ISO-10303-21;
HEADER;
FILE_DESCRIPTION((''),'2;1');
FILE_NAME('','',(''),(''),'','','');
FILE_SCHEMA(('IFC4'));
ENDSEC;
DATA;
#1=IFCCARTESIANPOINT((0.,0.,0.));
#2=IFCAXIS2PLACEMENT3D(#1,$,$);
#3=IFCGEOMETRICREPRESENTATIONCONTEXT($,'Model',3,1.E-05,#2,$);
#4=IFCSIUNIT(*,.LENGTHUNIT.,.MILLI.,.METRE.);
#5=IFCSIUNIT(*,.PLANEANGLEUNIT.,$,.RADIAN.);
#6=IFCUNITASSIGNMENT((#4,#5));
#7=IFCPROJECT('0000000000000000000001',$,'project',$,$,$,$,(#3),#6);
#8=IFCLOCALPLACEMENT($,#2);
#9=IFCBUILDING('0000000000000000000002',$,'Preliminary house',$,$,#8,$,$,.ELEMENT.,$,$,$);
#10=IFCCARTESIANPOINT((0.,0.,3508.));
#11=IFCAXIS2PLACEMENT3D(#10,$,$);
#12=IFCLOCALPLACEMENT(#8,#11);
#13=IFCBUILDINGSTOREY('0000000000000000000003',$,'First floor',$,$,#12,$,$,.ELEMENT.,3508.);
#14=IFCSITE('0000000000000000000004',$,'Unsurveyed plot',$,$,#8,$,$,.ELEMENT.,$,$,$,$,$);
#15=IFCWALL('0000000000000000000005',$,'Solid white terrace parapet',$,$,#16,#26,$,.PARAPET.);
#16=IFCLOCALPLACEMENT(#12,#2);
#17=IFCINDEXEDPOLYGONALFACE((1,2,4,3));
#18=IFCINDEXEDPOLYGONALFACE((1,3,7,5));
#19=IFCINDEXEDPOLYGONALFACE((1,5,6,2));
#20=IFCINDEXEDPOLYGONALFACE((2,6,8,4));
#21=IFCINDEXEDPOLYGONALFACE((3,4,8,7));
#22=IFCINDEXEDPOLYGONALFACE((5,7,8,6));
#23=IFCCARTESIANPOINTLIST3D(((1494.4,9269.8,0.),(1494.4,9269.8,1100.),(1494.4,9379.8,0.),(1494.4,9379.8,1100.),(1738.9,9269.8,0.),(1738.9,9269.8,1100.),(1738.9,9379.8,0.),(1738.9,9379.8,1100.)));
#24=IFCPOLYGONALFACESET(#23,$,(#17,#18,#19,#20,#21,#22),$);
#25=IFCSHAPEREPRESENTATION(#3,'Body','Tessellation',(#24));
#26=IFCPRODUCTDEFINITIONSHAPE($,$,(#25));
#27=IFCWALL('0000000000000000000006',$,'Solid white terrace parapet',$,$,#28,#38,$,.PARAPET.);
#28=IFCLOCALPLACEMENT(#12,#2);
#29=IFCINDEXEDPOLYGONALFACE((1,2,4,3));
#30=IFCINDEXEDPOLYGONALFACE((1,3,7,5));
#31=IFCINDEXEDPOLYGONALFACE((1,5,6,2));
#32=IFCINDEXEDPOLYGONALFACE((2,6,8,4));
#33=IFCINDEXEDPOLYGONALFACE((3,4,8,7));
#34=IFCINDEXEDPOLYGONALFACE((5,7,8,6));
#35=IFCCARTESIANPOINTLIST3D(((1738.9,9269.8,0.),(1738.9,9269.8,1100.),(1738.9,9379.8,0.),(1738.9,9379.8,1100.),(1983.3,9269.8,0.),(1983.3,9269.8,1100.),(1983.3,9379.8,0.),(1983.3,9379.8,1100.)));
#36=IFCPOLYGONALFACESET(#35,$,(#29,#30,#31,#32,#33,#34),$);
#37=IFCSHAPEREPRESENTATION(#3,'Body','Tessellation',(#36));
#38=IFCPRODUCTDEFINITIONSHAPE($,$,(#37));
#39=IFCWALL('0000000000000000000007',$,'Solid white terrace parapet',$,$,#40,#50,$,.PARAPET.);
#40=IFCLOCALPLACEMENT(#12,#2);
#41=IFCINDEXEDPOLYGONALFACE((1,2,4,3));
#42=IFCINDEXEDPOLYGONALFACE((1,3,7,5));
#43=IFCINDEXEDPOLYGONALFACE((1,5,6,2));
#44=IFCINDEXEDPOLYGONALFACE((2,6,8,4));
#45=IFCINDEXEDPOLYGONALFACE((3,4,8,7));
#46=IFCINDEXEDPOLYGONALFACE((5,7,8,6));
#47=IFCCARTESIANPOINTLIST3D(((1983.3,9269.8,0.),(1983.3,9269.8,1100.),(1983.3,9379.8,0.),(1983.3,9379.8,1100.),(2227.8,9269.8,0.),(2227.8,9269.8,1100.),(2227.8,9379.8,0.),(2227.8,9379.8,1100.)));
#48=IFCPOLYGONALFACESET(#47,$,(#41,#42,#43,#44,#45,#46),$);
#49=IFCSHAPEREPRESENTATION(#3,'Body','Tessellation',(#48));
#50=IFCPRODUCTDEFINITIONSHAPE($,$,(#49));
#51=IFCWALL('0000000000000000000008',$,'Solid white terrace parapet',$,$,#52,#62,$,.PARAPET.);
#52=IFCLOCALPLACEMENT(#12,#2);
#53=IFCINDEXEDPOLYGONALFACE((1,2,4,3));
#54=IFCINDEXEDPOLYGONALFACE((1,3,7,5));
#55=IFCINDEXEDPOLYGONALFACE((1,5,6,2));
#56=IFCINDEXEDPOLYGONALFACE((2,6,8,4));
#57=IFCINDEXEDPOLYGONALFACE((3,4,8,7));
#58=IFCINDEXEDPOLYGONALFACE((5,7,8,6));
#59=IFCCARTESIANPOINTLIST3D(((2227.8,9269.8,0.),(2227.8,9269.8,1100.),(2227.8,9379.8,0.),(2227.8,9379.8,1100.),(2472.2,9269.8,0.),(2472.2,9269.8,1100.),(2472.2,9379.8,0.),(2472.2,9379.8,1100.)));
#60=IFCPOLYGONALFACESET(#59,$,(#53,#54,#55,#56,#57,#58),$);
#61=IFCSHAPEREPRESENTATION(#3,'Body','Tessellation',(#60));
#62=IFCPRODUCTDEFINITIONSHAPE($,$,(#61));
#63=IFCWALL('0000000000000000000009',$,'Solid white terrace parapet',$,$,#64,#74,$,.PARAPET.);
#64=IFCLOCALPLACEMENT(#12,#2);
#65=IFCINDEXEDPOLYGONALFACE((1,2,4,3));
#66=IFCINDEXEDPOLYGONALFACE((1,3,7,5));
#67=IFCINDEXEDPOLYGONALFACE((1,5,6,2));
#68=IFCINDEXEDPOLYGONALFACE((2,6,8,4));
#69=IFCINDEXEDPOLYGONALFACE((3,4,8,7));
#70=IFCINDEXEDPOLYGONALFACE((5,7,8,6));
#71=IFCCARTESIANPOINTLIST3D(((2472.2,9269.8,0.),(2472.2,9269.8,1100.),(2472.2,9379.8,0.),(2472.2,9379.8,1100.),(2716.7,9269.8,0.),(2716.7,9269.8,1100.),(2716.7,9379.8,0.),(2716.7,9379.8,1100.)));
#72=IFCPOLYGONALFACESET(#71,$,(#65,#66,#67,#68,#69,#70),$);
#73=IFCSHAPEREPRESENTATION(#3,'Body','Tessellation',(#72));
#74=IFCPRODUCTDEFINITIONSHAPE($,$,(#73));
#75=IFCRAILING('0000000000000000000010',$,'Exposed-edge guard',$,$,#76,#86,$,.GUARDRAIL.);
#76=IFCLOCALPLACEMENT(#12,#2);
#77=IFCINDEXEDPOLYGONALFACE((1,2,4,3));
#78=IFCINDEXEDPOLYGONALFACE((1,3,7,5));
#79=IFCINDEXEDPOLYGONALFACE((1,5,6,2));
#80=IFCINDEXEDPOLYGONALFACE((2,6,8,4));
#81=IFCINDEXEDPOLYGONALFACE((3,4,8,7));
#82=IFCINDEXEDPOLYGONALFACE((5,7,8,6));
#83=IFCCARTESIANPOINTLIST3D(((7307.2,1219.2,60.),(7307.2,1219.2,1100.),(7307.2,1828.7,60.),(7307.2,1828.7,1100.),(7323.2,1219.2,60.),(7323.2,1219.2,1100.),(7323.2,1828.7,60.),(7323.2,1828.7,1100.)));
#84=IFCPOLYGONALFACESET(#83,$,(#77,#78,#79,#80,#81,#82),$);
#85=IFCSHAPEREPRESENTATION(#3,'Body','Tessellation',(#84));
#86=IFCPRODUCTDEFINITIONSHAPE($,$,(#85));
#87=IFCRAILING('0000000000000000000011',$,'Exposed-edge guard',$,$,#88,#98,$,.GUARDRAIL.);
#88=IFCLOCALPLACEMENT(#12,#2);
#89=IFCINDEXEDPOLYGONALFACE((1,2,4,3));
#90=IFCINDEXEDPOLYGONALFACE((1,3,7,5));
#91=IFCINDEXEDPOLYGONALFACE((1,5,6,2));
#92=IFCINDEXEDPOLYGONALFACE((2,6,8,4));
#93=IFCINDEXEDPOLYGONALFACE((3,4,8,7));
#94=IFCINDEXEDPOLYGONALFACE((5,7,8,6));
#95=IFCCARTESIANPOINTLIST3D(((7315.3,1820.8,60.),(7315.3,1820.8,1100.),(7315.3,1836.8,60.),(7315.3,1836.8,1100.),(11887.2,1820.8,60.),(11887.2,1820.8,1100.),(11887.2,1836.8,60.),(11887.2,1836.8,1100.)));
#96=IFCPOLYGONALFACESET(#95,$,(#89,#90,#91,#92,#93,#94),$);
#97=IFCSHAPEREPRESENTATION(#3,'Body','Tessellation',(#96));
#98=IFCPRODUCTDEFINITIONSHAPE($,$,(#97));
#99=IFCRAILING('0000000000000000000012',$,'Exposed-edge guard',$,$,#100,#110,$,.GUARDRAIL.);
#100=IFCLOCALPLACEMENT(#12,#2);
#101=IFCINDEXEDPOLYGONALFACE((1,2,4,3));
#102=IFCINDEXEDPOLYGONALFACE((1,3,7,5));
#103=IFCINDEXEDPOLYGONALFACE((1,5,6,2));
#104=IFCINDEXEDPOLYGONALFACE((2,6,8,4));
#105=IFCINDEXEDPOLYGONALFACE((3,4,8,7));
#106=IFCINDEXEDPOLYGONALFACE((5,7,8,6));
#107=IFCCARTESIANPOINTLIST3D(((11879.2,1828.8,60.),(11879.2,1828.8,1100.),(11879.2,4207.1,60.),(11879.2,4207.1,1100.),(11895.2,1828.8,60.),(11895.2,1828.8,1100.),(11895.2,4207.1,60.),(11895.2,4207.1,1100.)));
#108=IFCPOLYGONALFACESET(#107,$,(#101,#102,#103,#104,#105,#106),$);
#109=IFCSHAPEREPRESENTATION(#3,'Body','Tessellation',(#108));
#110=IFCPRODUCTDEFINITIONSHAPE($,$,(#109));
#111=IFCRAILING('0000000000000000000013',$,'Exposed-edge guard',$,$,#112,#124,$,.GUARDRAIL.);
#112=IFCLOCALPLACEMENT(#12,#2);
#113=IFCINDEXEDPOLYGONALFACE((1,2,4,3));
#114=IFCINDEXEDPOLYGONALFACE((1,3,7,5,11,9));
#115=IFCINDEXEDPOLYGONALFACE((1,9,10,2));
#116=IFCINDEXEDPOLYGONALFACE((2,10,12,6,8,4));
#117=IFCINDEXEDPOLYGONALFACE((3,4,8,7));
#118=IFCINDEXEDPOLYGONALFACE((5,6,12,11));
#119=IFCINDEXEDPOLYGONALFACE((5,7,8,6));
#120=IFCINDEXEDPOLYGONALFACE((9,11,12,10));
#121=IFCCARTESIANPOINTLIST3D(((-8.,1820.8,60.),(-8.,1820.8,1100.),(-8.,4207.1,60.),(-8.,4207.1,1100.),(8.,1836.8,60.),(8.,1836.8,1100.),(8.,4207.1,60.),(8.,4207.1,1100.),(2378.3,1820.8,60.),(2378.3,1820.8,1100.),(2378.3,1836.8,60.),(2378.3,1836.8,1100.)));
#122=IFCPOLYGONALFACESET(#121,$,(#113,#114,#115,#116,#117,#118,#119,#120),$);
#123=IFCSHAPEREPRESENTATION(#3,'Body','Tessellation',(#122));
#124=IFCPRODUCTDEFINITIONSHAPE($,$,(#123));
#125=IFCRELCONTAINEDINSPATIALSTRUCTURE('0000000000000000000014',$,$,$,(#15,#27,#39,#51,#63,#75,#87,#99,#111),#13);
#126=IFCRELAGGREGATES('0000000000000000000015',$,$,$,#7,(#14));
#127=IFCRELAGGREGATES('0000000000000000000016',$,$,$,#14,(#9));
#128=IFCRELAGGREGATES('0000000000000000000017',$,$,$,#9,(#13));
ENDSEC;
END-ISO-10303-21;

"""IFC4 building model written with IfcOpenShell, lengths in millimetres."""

from ifc_helpers import new_model, si_unit, frame, origin, place, context, project, spatial, polyline, outline, extrude, element, save


model = new_model("IFC4")

# Units and contexts
model_context = context("Model", 3, precision=1e-05, world=origin())
ifc_project = project(units=[si_unit("LENGTHUNIT", "METRE", prefix="MILLI"), si_unit("PLANEANGLEUNIT", "RADIAN")], contexts=[model_context])

# Site, building, storey
placement_1 = place(None, origin())
site = spatial("IfcSite", under=ifc_project, at=placement_1, Name="Unsurveyed plot", CompositionType="ELEMENT")
building = spatial("IfcBuilding", under=site, at=placement_1, Name="Preliminary house", CompositionType="ELEMENT")
placement_2 = place(placement_1, frame((0.0, 0.0, 3508.0)))
storey = spatial("IfcBuildingStorey", under=building, at=placement_2, Name="First floor", CompositionType="ELEMENT", Elevation=3508.0)

# Walls
element("IfcWall", 1, at=placement_2, inside=storey, Name="Solid white terrace parapet", PredefinedType="PARAPET", context=model_context, shape_type="SweptSolid", body=[
    extrude(outline(polyline([(1738.9, 9379.8), (1738.9, 9269.8), (1494.4, 9269.8), (1494.4, 9379.8), (1738.9, 9379.8)])), origin(), (0.0, 0.0, 1.0), 1100.0),
])
element("IfcWall", 2, at=placement_2, inside=storey, Name="Solid white terrace parapet", PredefinedType="PARAPET", context=model_context, shape_type="SweptSolid", body=[
    extrude(outline(polyline([(1983.3, 9379.8), (1983.3, 9269.8), (1738.9, 9269.8), (1738.9, 9379.8), (1983.3, 9379.8)])), origin(), (0.0, 0.0, 1.0), 1100.0),
])
element("IfcWall", 3, at=placement_2, inside=storey, Name="Solid white terrace parapet", PredefinedType="PARAPET", context=model_context, shape_type="SweptSolid", body=[
    extrude(outline(polyline([(2227.8, 9379.8), (2227.8, 9269.8), (1983.3, 9269.8), (1983.3, 9379.8), (2227.8, 9379.8)])), origin(), (0.0, 0.0, 1.0), 1100.0),
])
element("IfcWall", 4, at=placement_2, inside=storey, Name="Solid white terrace parapet", PredefinedType="PARAPET", context=model_context, shape_type="SweptSolid", body=[
    extrude(outline(polyline([(2472.2, 9379.8), (2472.2, 9269.8), (2227.8, 9269.8), (2227.8, 9379.8), (2472.2, 9379.8)])), origin(), (0.0, 0.0, 1.0), 1100.0),
])
element("IfcWall", 5, at=placement_2, inside=storey, Name="Solid white terrace parapet", PredefinedType="PARAPET", context=model_context, shape_type="SweptSolid", body=[
    extrude(outline(polyline([(2716.7, 9379.8), (2716.7, 9269.8), (2472.2, 9269.8), (2472.2, 9379.8), (2716.7, 9379.8)])), origin(), (0.0, 0.0, 1.0), 1100.0),
])

# Railings
element("IfcRailing", 6, at=placement_2, inside=storey, Name="Exposed-edge guard", PredefinedType="GUARDRAIL", context=model_context, shape_type="SweptSolid", body=[
    extrude(outline(polyline([(7323.2, 1219.2), (7307.2, 1219.2), (7307.2, 1828.7), (7323.2, 1828.7), (7323.2, 1219.2)])), frame((0.0, 0.0, 60.0)), (0.0, 0.0, 1.0), 1040.0),
])
element("IfcRailing", 7, at=placement_2, inside=storey, Name="Exposed-edge guard", PredefinedType="GUARDRAIL", context=model_context, shape_type="SweptSolid", body=[
    extrude(outline(polyline([(7315.3, 1820.8), (7315.3, 1836.8), (11887.2, 1836.8), (11887.2, 1820.8), (7315.3, 1820.8)])), frame((0.0, 0.0, 60.0)), (0.0, 0.0, 1.0), 1040.0),
])
element("IfcRailing", 8, at=placement_2, inside=storey, Name="Exposed-edge guard", PredefinedType="GUARDRAIL", context=model_context, shape_type="SweptSolid", body=[
    extrude(outline(polyline([(11895.2, 1828.8), (11879.2, 1828.8), (11879.2, 4207.1), (11895.2, 4207.1), (11895.2, 1828.8)])), frame((0.0, 0.0, 60.0)), (0.0, 0.0, 1.0), 1040.0),
])
element("IfcRailing", 9, at=placement_2, inside=storey, Name="Exposed-edge guard", PredefinedType="GUARDRAIL", context=model_context, shape_type="SweptSolid", body=[
    extrude(outline(polyline([(-8.0, 1820.8), (-8.0, 4207.1), (8.0, 4207.1), (8.0, 1836.8), (2378.3, 1836.8), (2378.3, 1820.8), (-8.0, 1820.8)])), frame((0.0, 0.0, 60.0)), (0.0, 0.0, 1.0), 1040.0),
])

save(model, "model.ifc")
